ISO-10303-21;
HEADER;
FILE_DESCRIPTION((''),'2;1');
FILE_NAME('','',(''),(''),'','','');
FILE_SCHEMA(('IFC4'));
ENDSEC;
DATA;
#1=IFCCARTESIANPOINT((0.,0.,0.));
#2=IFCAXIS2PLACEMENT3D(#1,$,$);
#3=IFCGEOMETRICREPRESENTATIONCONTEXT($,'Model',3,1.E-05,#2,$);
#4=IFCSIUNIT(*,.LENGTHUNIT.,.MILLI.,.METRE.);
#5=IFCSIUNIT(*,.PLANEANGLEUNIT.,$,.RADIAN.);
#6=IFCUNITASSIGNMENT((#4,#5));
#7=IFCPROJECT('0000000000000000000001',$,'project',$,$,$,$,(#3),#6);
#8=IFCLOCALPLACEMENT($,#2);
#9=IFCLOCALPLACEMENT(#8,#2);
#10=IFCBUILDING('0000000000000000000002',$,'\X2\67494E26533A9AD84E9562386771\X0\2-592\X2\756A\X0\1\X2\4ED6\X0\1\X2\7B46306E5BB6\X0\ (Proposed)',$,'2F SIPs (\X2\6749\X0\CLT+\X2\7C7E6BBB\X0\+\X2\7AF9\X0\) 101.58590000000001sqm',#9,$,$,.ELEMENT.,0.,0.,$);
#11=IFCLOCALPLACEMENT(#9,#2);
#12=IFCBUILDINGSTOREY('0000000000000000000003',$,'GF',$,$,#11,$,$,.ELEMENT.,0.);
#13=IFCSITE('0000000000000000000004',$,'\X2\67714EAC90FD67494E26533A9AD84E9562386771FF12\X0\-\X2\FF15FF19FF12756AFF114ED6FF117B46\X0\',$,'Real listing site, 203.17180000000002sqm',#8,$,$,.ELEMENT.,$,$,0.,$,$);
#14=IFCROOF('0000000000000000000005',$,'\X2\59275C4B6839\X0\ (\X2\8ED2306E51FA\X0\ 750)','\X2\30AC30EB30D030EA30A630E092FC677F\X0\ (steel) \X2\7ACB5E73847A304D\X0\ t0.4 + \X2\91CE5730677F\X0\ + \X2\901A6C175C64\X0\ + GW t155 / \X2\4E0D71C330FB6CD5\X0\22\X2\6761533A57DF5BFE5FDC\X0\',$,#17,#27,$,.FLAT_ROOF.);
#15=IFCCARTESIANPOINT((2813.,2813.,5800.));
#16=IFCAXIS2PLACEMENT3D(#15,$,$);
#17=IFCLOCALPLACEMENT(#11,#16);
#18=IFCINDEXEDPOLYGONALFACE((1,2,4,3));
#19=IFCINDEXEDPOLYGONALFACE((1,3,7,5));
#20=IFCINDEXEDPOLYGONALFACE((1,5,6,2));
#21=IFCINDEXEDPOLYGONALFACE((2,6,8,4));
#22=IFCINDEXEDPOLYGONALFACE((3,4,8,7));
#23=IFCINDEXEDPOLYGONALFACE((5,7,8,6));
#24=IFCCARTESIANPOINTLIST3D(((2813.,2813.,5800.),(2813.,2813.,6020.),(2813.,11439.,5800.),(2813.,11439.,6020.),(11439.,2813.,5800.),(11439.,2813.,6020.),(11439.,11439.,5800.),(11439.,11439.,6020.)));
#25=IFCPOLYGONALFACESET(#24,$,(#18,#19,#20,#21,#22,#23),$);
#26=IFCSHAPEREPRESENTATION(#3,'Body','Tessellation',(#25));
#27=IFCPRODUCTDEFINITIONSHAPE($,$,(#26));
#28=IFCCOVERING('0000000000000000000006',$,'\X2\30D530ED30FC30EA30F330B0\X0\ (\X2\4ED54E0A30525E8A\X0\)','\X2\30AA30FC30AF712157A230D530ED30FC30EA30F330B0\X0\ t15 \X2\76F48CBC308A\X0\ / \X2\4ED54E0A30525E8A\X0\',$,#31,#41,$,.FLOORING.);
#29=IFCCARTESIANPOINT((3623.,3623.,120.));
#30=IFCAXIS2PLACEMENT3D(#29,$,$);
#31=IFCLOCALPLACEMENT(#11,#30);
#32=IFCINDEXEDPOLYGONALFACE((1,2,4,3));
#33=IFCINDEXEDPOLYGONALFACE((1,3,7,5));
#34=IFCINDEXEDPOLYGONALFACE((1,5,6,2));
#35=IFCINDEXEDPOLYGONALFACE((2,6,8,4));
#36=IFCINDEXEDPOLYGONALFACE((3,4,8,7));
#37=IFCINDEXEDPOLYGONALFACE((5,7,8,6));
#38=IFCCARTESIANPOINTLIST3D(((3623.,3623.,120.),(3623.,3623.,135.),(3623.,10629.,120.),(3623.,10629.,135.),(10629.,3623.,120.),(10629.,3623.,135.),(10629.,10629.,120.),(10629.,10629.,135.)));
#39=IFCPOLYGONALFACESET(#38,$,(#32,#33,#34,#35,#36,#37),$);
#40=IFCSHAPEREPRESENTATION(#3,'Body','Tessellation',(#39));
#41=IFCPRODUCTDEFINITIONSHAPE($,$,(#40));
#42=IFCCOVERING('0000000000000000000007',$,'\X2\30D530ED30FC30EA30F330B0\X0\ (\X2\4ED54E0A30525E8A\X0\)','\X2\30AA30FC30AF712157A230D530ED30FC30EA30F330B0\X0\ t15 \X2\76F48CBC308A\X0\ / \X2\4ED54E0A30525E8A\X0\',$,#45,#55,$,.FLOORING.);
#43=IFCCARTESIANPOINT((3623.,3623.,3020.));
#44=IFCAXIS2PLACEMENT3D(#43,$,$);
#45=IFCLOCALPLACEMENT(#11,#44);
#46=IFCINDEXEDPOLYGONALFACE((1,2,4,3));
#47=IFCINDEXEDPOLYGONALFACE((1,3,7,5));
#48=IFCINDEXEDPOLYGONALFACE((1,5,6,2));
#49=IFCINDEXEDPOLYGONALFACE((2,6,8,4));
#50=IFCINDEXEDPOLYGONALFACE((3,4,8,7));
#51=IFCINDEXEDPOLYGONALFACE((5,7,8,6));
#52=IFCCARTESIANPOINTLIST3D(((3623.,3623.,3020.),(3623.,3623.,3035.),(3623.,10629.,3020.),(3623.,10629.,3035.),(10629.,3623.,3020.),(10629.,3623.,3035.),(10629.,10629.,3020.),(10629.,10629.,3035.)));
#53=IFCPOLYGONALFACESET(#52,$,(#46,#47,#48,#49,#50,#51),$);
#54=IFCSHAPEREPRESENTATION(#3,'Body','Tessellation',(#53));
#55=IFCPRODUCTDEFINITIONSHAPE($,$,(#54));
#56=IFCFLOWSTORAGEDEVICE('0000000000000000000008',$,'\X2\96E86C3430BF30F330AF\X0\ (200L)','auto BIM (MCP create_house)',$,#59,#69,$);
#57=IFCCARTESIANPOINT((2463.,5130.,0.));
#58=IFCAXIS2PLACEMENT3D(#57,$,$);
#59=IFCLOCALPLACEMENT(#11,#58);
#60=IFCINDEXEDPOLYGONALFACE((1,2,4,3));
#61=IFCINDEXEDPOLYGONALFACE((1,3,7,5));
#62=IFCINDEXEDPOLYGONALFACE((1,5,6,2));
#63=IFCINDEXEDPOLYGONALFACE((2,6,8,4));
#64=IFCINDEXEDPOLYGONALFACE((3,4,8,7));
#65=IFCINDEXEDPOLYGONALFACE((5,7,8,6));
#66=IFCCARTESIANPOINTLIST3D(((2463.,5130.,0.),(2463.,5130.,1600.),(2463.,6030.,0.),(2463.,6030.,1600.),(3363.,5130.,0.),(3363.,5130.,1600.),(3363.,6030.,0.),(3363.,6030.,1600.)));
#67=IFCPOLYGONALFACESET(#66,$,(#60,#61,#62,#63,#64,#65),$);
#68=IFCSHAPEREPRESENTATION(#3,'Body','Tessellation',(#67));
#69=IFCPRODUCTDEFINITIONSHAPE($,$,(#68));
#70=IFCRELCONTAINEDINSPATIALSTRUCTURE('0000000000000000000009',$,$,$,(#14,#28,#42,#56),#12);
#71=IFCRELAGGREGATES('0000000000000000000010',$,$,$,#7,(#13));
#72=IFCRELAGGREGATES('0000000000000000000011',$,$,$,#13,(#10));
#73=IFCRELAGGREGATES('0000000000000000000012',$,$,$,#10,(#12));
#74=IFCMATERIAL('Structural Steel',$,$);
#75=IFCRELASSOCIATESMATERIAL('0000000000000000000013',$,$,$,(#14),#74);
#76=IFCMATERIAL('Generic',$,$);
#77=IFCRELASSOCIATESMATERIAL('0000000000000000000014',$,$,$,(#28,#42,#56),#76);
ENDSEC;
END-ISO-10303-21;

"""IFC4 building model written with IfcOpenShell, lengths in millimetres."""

from ifc_helpers import new_model, si_unit, frame, frame_2d, origin, place, context, project, spatial, rectangle, extrude, material, element, save


model = new_model("IFC4")

# Units and contexts
model_context = context("Model", 3, precision=1e-05, world=origin())
ifc_project = project(units=[si_unit("LENGTHUNIT", "METRE", prefix="MILLI"), si_unit("PLANEANGLEUNIT", "RADIAN")], contexts=[model_context])

# Site, building, storey
site_placement = place(None, origin())
site = spatial("IfcSite", under=ifc_project, at=site_placement, Name="東京都杉並区高井戸東２-５９２番１他１筆", ObjectType="Real listing site, 203.17180000000002sqm", CompositionType="ELEMENT", RefElevation=0.0)
building_placement = place(site_placement, origin())
building = spatial("IfcBuilding", under=site, at=building_placement, Name="杉並区高井戸東2-592番1他1筆の家 (Proposed)", ObjectType="2F SIPs (杉CLT+籾殻+竹) 101.58590000000001sqm", CompositionType="ELEMENT", ElevationOfRefHeight=0.0, ElevationOfTerrain=0.0)
storey_placement = place(building_placement, origin())
storey = spatial("IfcBuildingStorey", under=building, at=storey_placement, Name="GF", CompositionType="ELEMENT", Elevation=0.0)

# Roof
ifc_material_1 = material(Name="Structural Steel")
roof_placement = place(storey_placement, frame((2813.0, 2813.0, 5800.0)))
element("IfcRoof", 1, at=roof_placement, inside=storey, material=ifc_material_1, Name="大屋根 (軒の出 750)", Description="ガルバリウム鋼板 (steel) 立平葺き t0.4 + 野地板 + 通気層 + GW t155 / 不燃・法22条区域対応", PredefinedType="FLAT_ROOF", context=model_context, shape_type="SweptSolid", body=[
    extrude(rectangle(XDim=8626.0, YDim=8626.0, at=frame_2d((4313.0, 4313.0))), frame((2813.0, 2813.0, 5800.0)), (0.0, 0.0, 1.0), 220.0),
])

# Coverings
ifc_material_2 = material(Name="Generic")
covering_1_placement = place(storey_placement, frame((3623.0, 3623.0, 120.0)))
element("IfcCovering", 2, at=covering_1_placement, inside=storey, material=ifc_material_2, Name="フローリング (仕上げ床)", Description="オーク無垢フローリング t15 直貼り / 仕上げ床", PredefinedType="FLOORING", context=model_context, shape_type="SweptSolid", body=[
    extrude(rectangle(XDim=7006.0, YDim=7006.0, at=frame_2d((3503.0, 3503.0))), frame((3623.0, 3623.0, 120.0)), (0.0, 0.0, 1.0), 15.0),
])
covering_2_placement = place(storey_placement, frame((3623.0, 3623.0, 3020.0)))
element("IfcCovering", 3, at=covering_2_placement, inside=storey, material=ifc_material_2, Name="フローリング (仕上げ床)", Description="オーク無垢フローリング t15 直貼り / 仕上げ床", PredefinedType="FLOORING", context=model_context, shape_type="SweptSolid", body=[
    extrude(rectangle(XDim=7006.0, YDim=7006.0, at=frame_2d((3503.0, 3503.0))), frame((3623.0, 3623.0, 3020.0)), (0.0, 0.0, 1.0), 15.0),
])

# Flow storage device
flow_storage_device_placement = place(storey_placement, frame((2463.0, 5130.0, 0.0)))
element("IfcFlowStorageDevice", 4, at=flow_storage_device_placement, inside=storey, material=ifc_material_2, Name="雨水タンク (200L)", Description="auto BIM (MCP create_house)", context=model_context, shape_type="SweptSolid", body=[
    extrude(rectangle(XDim=900.0, YDim=900.0, at=frame_2d((450.0, 450.0))), frame((2463.0, 5130.0, 0.0)), (0.0, 0.0, 1.0), 1600.0),
])

save(model, "model.ifc")
